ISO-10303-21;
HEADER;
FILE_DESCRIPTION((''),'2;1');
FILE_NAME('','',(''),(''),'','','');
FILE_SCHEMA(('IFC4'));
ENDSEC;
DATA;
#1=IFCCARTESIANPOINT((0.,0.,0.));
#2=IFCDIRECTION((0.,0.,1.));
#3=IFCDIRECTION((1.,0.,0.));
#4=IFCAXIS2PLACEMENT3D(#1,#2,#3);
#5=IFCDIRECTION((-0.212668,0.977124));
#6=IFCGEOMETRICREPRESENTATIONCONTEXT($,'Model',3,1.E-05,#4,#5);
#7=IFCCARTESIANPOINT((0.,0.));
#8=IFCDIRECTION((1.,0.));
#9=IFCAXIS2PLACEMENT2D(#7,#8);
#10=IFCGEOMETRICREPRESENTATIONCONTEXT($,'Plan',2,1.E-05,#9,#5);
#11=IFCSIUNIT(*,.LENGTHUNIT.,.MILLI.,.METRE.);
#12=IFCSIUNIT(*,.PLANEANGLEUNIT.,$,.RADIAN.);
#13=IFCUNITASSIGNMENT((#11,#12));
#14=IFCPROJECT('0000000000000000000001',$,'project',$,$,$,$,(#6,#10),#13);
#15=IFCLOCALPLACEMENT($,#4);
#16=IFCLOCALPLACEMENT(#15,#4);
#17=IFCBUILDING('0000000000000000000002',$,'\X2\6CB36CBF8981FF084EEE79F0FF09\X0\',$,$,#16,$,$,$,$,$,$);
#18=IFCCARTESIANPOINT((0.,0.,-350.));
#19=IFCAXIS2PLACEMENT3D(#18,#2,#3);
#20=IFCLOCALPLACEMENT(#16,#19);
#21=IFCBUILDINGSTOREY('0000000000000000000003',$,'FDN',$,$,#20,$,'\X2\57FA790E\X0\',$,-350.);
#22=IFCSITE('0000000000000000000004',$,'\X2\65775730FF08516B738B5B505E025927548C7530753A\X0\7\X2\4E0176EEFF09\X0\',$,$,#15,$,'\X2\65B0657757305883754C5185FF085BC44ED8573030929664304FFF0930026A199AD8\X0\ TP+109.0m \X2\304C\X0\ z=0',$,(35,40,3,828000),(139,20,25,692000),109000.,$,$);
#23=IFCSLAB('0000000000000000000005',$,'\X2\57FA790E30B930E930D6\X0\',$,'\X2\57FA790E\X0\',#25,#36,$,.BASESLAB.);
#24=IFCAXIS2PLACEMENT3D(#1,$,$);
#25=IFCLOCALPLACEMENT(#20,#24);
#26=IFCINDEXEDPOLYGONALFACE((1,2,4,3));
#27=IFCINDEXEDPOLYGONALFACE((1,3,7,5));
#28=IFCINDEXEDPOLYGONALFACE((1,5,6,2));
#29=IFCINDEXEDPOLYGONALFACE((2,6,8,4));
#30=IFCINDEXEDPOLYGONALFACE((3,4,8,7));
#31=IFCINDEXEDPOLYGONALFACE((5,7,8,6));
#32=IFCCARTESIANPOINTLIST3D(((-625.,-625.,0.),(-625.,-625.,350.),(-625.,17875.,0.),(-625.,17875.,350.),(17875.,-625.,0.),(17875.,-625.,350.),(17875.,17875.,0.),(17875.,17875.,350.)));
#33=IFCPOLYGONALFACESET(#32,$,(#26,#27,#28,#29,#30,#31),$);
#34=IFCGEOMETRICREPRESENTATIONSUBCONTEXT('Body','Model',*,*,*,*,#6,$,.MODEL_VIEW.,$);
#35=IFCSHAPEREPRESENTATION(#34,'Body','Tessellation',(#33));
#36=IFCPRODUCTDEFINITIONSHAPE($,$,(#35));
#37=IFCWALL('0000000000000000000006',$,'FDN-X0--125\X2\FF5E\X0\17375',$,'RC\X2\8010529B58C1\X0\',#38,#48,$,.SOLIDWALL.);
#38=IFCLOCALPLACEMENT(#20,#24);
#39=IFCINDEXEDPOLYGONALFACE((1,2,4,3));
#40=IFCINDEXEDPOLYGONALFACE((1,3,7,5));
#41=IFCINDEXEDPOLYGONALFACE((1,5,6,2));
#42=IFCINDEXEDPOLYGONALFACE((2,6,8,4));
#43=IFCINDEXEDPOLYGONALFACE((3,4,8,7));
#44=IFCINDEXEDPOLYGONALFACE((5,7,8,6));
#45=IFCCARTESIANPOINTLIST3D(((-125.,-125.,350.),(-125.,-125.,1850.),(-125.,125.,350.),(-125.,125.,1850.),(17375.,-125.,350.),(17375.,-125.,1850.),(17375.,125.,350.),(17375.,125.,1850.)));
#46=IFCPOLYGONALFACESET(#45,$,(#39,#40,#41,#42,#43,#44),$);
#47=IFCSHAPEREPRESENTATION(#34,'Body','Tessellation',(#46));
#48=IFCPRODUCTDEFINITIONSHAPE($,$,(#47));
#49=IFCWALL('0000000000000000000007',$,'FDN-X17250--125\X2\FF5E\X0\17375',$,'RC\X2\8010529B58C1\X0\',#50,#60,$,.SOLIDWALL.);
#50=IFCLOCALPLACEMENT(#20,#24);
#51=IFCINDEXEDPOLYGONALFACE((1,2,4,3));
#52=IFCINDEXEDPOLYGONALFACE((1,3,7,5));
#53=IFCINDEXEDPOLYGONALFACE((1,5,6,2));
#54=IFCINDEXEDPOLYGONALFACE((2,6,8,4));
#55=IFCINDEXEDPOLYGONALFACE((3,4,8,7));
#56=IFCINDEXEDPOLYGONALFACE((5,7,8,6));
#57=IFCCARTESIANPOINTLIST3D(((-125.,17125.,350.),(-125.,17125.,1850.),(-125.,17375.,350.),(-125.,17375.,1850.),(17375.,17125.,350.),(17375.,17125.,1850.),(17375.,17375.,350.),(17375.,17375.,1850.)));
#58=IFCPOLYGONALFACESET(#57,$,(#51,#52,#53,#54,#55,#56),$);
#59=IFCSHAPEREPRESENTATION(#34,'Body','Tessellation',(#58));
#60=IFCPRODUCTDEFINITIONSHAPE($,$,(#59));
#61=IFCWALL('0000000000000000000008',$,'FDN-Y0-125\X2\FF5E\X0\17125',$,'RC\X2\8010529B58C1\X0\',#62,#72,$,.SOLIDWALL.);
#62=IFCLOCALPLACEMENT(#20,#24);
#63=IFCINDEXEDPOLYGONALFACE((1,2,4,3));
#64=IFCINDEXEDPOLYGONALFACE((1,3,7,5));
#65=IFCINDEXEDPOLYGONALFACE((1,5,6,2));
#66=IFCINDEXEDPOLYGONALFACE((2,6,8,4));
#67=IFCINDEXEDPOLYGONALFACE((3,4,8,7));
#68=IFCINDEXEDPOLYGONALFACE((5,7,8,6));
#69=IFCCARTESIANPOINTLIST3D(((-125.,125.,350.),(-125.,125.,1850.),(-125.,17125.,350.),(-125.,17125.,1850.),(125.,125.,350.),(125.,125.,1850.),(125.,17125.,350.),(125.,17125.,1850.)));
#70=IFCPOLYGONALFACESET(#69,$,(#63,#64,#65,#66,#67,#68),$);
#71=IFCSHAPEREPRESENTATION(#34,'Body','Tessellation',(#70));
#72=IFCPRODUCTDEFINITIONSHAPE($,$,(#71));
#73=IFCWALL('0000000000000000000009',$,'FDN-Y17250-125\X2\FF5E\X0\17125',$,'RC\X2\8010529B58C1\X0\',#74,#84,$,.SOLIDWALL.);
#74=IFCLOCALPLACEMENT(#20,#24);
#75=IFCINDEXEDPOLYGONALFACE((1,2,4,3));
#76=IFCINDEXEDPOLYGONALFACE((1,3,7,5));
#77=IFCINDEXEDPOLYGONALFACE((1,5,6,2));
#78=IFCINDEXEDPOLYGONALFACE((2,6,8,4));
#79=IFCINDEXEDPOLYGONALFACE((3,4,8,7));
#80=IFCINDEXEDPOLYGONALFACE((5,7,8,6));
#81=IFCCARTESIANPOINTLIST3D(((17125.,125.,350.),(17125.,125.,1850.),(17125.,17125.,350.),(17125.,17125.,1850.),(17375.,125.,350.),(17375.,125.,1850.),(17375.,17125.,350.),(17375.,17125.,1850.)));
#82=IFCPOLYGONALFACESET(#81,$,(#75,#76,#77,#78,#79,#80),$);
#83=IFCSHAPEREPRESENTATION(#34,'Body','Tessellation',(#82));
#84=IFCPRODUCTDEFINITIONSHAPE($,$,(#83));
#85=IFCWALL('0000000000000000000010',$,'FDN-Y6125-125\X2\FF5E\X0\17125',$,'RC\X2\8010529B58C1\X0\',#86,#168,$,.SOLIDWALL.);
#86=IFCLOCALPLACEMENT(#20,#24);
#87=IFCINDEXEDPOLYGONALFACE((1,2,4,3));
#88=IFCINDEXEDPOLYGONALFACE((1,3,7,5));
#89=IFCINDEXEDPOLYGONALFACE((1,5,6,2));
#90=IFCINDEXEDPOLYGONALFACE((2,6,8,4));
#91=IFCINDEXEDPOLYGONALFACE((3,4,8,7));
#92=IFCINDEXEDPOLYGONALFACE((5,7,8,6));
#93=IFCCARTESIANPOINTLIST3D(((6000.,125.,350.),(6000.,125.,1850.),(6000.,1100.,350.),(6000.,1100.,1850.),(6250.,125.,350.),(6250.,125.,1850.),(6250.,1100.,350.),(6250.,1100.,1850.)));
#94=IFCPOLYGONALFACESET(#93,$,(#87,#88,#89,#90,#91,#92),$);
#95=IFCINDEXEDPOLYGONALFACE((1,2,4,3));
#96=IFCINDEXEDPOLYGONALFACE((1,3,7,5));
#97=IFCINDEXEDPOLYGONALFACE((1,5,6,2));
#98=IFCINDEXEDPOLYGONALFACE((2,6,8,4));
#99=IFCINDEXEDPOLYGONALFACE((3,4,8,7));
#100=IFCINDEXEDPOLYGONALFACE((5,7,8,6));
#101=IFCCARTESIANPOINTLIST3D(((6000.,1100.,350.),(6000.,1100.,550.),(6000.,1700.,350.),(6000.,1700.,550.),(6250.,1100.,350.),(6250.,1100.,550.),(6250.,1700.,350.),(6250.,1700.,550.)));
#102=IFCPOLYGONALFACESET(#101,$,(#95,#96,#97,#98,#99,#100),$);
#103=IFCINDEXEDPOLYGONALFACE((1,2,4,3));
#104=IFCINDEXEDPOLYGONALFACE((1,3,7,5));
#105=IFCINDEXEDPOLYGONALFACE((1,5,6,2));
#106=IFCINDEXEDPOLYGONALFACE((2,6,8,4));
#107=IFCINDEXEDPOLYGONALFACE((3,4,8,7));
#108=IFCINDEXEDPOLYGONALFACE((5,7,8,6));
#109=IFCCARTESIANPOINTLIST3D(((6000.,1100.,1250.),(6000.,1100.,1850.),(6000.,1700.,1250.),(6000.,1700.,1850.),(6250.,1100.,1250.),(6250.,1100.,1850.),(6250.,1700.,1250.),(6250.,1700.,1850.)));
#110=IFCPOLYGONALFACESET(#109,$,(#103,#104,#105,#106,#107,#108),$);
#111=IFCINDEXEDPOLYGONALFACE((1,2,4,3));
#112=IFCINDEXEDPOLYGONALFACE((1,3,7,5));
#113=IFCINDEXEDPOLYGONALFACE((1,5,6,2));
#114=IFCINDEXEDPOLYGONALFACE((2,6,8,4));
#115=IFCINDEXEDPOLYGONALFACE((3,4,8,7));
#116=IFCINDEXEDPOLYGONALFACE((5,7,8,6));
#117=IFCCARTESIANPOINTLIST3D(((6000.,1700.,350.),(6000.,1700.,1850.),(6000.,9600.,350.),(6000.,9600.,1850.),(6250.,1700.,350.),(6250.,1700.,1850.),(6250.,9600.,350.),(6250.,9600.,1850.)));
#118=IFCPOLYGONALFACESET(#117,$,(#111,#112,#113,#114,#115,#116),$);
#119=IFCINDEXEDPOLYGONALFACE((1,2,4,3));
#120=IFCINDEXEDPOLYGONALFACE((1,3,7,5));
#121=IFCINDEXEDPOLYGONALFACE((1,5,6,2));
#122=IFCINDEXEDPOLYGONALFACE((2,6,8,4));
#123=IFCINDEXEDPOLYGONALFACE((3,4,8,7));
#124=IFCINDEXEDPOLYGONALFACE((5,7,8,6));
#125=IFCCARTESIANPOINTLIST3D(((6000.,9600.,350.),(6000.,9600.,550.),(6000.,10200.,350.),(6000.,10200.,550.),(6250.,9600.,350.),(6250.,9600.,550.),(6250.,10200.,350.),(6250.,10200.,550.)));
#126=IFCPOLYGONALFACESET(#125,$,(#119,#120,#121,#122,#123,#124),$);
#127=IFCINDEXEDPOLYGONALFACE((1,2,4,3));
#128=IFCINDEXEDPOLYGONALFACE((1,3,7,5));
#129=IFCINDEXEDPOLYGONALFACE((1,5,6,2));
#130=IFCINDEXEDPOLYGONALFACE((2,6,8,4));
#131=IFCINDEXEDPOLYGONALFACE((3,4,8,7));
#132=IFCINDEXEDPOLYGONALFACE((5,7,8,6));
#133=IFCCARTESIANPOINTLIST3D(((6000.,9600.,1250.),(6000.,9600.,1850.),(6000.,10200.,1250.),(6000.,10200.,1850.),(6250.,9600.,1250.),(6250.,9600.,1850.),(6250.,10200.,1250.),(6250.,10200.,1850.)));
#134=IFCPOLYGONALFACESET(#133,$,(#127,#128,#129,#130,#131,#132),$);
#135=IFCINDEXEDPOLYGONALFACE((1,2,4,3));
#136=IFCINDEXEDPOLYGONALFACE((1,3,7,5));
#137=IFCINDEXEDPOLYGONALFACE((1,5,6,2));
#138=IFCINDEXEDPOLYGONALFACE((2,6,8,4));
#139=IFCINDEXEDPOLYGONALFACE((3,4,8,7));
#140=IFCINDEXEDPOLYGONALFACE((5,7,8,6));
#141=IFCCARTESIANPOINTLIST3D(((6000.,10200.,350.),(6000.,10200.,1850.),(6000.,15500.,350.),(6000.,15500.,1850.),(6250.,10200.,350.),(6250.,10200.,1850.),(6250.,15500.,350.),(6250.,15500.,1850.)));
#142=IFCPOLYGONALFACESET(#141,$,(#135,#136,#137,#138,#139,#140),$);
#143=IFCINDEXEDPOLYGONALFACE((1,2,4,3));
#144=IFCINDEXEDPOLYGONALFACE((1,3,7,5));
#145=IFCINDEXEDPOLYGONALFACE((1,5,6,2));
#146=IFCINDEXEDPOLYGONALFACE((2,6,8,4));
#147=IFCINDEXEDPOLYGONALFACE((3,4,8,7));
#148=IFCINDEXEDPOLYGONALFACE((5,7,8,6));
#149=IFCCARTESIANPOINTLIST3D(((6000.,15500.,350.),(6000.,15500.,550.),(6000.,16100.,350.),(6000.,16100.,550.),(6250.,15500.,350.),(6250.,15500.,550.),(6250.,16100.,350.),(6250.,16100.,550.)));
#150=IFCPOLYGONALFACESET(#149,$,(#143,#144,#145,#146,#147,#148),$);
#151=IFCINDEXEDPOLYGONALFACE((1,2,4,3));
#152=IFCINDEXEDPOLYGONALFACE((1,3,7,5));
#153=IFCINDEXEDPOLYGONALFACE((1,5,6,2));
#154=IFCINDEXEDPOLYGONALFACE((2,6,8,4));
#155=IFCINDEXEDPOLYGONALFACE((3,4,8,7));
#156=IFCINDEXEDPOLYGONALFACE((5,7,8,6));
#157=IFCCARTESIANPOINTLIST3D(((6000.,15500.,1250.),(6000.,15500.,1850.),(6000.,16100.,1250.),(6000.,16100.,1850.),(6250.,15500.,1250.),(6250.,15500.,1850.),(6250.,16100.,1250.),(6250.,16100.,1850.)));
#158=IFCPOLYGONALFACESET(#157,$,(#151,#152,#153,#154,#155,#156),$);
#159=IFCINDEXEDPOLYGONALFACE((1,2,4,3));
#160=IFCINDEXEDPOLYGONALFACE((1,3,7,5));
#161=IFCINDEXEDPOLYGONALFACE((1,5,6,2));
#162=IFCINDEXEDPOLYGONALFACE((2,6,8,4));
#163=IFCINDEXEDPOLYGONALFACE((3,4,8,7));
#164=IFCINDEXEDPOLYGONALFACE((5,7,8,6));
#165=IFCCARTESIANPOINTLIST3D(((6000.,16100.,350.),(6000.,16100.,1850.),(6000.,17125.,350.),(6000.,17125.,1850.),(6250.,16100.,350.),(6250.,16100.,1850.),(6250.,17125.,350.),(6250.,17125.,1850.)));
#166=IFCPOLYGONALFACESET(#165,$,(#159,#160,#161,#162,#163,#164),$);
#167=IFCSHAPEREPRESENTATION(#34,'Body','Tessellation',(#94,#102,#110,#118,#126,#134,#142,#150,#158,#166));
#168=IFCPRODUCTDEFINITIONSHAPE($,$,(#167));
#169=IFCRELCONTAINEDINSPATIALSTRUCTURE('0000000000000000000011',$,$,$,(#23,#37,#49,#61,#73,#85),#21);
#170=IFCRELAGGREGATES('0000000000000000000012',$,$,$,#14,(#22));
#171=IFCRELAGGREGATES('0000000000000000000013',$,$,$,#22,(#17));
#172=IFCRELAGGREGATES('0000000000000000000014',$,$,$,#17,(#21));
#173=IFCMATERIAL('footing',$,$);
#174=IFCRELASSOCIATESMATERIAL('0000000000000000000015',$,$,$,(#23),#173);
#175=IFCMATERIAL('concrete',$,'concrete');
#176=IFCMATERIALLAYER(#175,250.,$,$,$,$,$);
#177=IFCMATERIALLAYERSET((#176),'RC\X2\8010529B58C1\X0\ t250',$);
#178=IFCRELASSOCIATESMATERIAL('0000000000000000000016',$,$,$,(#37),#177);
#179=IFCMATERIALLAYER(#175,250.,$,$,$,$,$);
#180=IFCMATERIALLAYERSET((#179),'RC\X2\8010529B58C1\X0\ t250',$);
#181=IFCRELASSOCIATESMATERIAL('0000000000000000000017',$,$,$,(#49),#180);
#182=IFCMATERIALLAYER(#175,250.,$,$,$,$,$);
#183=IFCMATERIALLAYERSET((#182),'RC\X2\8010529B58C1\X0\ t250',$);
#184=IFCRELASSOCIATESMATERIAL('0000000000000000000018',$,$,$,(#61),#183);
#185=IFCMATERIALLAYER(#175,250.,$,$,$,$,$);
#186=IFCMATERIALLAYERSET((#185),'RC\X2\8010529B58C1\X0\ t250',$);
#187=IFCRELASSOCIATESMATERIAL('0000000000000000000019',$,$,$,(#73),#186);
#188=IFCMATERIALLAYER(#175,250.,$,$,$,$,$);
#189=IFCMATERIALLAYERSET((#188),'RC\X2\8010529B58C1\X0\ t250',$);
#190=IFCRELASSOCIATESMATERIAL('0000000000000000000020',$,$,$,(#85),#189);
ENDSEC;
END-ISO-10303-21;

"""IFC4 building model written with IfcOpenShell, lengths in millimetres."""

from ifc_helpers import new_model, si_unit, direction, frame, frame_2d, origin, origin_with_axes, origin_2d_with_axis, place, context, subcontext, project, spatial, rectangle, extrude, material, layer, layer_set, layer_usage, element, save


model = new_model("IFC4")

# Units and contexts
model_context = context("Model", 3, precision=1e-05, world=origin_with_axes(), true_north=direction((-0.212668, 0.977124)))
plan_context = context("Plan", 2, precision=1e-05, world=origin_2d_with_axis(), true_north=direction((-0.212668, 0.977124)))
body_context = subcontext(model_context, "Body", "Model", "MODEL_VIEW")
ifc_project = project(units=[si_unit("LENGTHUNIT", "METRE", prefix="MILLI"), si_unit("PLANEANGLEUNIT", "RADIAN")], contexts=[model_context, plan_context])

# Site, building, storey
site_placement = place(None, origin_with_axes())
site = spatial("IfcSite", under=ifc_project, at=site_placement, Name="敷地（八王子市大和田町7丁目）", LongName="新敷地境界内（寄付地を除く）。標高 TP+109.0m が z=0", RefLatitude=(35, 40, 3, 828000), RefLongitude=(139, 20, 25, 692000), RefElevation=109000.0)
building_placement = place(site_placement, origin_with_axes())
building = spatial("IfcBuilding", under=site, at=building_placement, Name="河沿要（仮称）")
storey_placement = place(building_placement, frame((0.0, 0.0, -350.0), z_axis=(0.0, 0.0, 1.0), x_axis=(1.0, 0.0, 0.0)))
storey = spatial("IfcBuildingStorey", under=building, at=storey_placement, Name="FDN", LongName="基礎", Elevation=-350.0)

# Slab
ifc_material_1 = material(Name="footing")
slab_placement = place(storey_placement, origin_with_axes())
element("IfcSlab", 1, at=slab_placement, inside=storey, material=ifc_material_1, Name="基礎スラブ", ObjectType="基礎", PredefinedType="BASESLAB", context=body_context, shape_type="SweptSolid", body=[
    extrude(rectangle(XDim=18500.0, YDim=18500.0, at=frame_2d((8625.0, 8625.0))), origin(), (0.0, 0.0, 1.0), 350.0),
])

# Walls
ifc_material_2 = material(Name="concrete", Category="concrete")
ifc_layer_1 = layer(ifc_material_2, 250.0)
ifc_layer_set_1 = layer_set([ifc_layer_1], Name="RC耐力壁 t250")
ifc_layer_usage_1 = layer_usage(ifc_layer_set_1, "AXIS2", "POSITIVE", 0.0)
wall_1_placement = place(storey_placement, origin_with_axes())
element("IfcWall", 2, at=wall_1_placement, inside=storey, material=ifc_layer_usage_1, Name="FDN-X0--125～17375", ObjectType="RC耐力壁", PredefinedType="SOLIDWALL", context=body_context, shape_type="SweptSolid", body=[
    extrude(rectangle(XDim=17500.0, YDim=250.0, at=frame_2d((8625.0, 0.0))), frame((0.0, 0.0, 350.0)), (0.0, 0.0, 1.0), 1500.0),
])
ifc_layer_2 = layer(ifc_material_2, 250.0)
ifc_layer_set_2 = layer_set([ifc_layer_2], Name="RC耐力壁 t250")
ifc_layer_usage_2 = layer_usage(ifc_layer_set_2, "AXIS2", "POSITIVE", 0.0)
wall_2_placement = place(storey_placement, origin_with_axes())
element("IfcWall", 3, at=wall_2_placement, inside=storey, material=ifc_layer_usage_2, Name="FDN-X17250--125～17375", ObjectType="RC耐力壁", PredefinedType="SOLIDWALL", context=body_context, shape_type="SweptSolid", body=[
    extrude(rectangle(XDim=17500.0, YDim=250.0, at=frame_2d((8625.0, 17250.0))), frame((0.0, 0.0, 350.0)), (0.0, 0.0, 1.0), 1500.0),
])
ifc_layer_3 = layer(ifc_material_2, 250.0)
ifc_layer_set_3 = layer_set([ifc_layer_3], Name="RC耐力壁 t250")
ifc_layer_usage_3 = layer_usage(ifc_layer_set_3, "AXIS2", "POSITIVE", 0.0)
wall_3_placement = place(storey_placement, origin_with_axes())
element("IfcWall", 4, at=wall_3_placement, inside=storey, material=ifc_layer_usage_3, Name="FDN-Y0-125～17125", ObjectType="RC耐力壁", PredefinedType="SOLIDWALL", context=body_context, shape_type="SweptSolid", body=[
    extrude(rectangle(XDim=250.0, YDim=17000.0, at=frame_2d((0.0, 8625.0))), frame((0.0, 0.0, 350.0)), (0.0, 0.0, 1.0), 1500.0),
])
ifc_layer_4 = layer(ifc_material_2, 250.0)
ifc_layer_set_4 = layer_set([ifc_layer_4], Name="RC耐力壁 t250")
ifc_layer_usage_4 = layer_usage(ifc_layer_set_4, "AXIS2", "POSITIVE", 0.0)
wall_4_placement = place(storey_placement, origin_with_axes())
element("IfcWall", 5, at=wall_4_placement, inside=storey, material=ifc_layer_usage_4, Name="FDN-Y17250-125～17125", ObjectType="RC耐力壁", PredefinedType="SOLIDWALL", context=body_context, shape_type="SweptSolid", body=[
    extrude(rectangle(XDim=250.0, YDim=17000.0, at=frame_2d((17250.0, 8625.0))), frame((0.0, 0.0, 350.0)), (0.0, 0.0, 1.0), 1500.0),
])

# Wall, openings
ifc_layer_5 = layer(ifc_material_2, 250.0)
ifc_layer_set_5 = layer_set([ifc_layer_5], Name="RC耐力壁 t250")
ifc_layer_usage_5 = layer_usage(ifc_layer_set_5, "AXIS2", "POSITIVE", 0.0)
wall_5_placement = place(storey_placement, origin_with_axes())
wall_5 = element("IfcWall", 6, at=wall_5_placement, inside=storey, material=ifc_layer_usage_5, Name="FDN-Y6125-125～17125", ObjectType="RC耐力壁", PredefinedType="SOLIDWALL", context=body_context, shape_type="SweptSolid", body=[
    extrude(rectangle(XDim=250.0, YDim=975.0, at=frame_2d((6125.0, 612.5))), frame((0.0, 0.0, 350.0)), (0.0, 0.0, 1.0), 1500.0),
    extrude(rectangle(XDim=250.0, YDim=600.0, at=frame_2d((6125.0, 1400.0))), frame((0.0, 0.0, 350.0)), (0.0, 0.0, 1.0), 200.0),
    extrude(rectangle(XDim=250.0, YDim=600.0, at=frame_2d((6125.0, 1400.0))), frame((0.0, 0.0, 1250.0)), (0.0, 0.0, 1.0), 600.0),
    extrude(rectangle(XDim=250.0, YDim=7900.0, at=frame_2d((6125.0, 5650.0))), frame((0.0, 0.0, 350.0)), (0.0, 0.0, 1.0), 1500.0),
    extrude(rectangle(XDim=250.0, YDim=600.0, at=frame_2d((6125.0, 9900.0))), frame((0.0, 0.0, 350.0)), (0.0, 0.0, 1.0), 200.0),
    extrude(rectangle(XDim=250.0, YDim=600.0, at=frame_2d((6125.0, 9900.0))), frame((0.0, 0.0, 1250.0)), (0.0, 0.0, 1.0), 600.0),
    extrude(rectangle(XDim=250.0, YDim=5300.0, at=frame_2d((6125.0, 12850.0))), frame((0.0, 0.0, 350.0)), (0.0, 0.0, 1.0), 1500.0),
    extrude(rectangle(XDim=250.0, YDim=600.0, at=frame_2d((6125.0, 15800.0))), frame((0.0, 0.0, 350.0)), (0.0, 0.0, 1.0), 200.0),
    extrude(rectangle(XDim=250.0, YDim=600.0, at=frame_2d((6125.0, 15800.0))), frame((0.0, 0.0, 1250.0)), (0.0, 0.0, 1.0), 600.0),
    extrude(rectangle(XDim=250.0, YDim=1025.0, at=frame_2d((6125.0, 16612.5))), frame((0.0, 0.0, 350.0)), (0.0, 0.0, 1.0), 1500.0),
])
opening_1_placement = place(storey_placement, origin_with_axes())
element("IfcOpeningElement", 7, at=opening_1_placement, inside=storey, cuts=wall_5, PredefinedType="OPENING", context=body_context, shape_type="SweptSolid", body=[
    extrude(rectangle(XDim=300.0, YDim=600.0, at=frame_2d((6125.0, 1400.0))), frame((0.0, 0.0, 550.0)), (0.0, 0.0, 1.0), 700.0),
])
opening_2_placement = place(storey_placement, origin_with_axes())
element("IfcOpeningElement", 8, at=opening_2_placement, inside=storey, cuts=wall_5, PredefinedType="OPENING", context=body_context, shape_type="SweptSolid", body=[
    extrude(rectangle(XDim=300.0, YDim=600.0, at=frame_2d((6125.0, 9900.0))), frame((0.0, 0.0, 550.0)), (0.0, 0.0, 1.0), 700.0),
])
opening_3_placement = place(storey_placement, origin_with_axes())
element("IfcOpeningElement", 9, at=opening_3_placement, inside=storey, cuts=wall_5, PredefinedType="OPENING", context=body_context, shape_type="SweptSolid", body=[
    extrude(rectangle(XDim=300.0, YDim=600.0, at=frame_2d((6125.0, 15800.0))), frame((0.0, 0.0, 550.0)), (0.0, 0.0, 1.0), 700.0),
])

save(model, "model.ifc")
